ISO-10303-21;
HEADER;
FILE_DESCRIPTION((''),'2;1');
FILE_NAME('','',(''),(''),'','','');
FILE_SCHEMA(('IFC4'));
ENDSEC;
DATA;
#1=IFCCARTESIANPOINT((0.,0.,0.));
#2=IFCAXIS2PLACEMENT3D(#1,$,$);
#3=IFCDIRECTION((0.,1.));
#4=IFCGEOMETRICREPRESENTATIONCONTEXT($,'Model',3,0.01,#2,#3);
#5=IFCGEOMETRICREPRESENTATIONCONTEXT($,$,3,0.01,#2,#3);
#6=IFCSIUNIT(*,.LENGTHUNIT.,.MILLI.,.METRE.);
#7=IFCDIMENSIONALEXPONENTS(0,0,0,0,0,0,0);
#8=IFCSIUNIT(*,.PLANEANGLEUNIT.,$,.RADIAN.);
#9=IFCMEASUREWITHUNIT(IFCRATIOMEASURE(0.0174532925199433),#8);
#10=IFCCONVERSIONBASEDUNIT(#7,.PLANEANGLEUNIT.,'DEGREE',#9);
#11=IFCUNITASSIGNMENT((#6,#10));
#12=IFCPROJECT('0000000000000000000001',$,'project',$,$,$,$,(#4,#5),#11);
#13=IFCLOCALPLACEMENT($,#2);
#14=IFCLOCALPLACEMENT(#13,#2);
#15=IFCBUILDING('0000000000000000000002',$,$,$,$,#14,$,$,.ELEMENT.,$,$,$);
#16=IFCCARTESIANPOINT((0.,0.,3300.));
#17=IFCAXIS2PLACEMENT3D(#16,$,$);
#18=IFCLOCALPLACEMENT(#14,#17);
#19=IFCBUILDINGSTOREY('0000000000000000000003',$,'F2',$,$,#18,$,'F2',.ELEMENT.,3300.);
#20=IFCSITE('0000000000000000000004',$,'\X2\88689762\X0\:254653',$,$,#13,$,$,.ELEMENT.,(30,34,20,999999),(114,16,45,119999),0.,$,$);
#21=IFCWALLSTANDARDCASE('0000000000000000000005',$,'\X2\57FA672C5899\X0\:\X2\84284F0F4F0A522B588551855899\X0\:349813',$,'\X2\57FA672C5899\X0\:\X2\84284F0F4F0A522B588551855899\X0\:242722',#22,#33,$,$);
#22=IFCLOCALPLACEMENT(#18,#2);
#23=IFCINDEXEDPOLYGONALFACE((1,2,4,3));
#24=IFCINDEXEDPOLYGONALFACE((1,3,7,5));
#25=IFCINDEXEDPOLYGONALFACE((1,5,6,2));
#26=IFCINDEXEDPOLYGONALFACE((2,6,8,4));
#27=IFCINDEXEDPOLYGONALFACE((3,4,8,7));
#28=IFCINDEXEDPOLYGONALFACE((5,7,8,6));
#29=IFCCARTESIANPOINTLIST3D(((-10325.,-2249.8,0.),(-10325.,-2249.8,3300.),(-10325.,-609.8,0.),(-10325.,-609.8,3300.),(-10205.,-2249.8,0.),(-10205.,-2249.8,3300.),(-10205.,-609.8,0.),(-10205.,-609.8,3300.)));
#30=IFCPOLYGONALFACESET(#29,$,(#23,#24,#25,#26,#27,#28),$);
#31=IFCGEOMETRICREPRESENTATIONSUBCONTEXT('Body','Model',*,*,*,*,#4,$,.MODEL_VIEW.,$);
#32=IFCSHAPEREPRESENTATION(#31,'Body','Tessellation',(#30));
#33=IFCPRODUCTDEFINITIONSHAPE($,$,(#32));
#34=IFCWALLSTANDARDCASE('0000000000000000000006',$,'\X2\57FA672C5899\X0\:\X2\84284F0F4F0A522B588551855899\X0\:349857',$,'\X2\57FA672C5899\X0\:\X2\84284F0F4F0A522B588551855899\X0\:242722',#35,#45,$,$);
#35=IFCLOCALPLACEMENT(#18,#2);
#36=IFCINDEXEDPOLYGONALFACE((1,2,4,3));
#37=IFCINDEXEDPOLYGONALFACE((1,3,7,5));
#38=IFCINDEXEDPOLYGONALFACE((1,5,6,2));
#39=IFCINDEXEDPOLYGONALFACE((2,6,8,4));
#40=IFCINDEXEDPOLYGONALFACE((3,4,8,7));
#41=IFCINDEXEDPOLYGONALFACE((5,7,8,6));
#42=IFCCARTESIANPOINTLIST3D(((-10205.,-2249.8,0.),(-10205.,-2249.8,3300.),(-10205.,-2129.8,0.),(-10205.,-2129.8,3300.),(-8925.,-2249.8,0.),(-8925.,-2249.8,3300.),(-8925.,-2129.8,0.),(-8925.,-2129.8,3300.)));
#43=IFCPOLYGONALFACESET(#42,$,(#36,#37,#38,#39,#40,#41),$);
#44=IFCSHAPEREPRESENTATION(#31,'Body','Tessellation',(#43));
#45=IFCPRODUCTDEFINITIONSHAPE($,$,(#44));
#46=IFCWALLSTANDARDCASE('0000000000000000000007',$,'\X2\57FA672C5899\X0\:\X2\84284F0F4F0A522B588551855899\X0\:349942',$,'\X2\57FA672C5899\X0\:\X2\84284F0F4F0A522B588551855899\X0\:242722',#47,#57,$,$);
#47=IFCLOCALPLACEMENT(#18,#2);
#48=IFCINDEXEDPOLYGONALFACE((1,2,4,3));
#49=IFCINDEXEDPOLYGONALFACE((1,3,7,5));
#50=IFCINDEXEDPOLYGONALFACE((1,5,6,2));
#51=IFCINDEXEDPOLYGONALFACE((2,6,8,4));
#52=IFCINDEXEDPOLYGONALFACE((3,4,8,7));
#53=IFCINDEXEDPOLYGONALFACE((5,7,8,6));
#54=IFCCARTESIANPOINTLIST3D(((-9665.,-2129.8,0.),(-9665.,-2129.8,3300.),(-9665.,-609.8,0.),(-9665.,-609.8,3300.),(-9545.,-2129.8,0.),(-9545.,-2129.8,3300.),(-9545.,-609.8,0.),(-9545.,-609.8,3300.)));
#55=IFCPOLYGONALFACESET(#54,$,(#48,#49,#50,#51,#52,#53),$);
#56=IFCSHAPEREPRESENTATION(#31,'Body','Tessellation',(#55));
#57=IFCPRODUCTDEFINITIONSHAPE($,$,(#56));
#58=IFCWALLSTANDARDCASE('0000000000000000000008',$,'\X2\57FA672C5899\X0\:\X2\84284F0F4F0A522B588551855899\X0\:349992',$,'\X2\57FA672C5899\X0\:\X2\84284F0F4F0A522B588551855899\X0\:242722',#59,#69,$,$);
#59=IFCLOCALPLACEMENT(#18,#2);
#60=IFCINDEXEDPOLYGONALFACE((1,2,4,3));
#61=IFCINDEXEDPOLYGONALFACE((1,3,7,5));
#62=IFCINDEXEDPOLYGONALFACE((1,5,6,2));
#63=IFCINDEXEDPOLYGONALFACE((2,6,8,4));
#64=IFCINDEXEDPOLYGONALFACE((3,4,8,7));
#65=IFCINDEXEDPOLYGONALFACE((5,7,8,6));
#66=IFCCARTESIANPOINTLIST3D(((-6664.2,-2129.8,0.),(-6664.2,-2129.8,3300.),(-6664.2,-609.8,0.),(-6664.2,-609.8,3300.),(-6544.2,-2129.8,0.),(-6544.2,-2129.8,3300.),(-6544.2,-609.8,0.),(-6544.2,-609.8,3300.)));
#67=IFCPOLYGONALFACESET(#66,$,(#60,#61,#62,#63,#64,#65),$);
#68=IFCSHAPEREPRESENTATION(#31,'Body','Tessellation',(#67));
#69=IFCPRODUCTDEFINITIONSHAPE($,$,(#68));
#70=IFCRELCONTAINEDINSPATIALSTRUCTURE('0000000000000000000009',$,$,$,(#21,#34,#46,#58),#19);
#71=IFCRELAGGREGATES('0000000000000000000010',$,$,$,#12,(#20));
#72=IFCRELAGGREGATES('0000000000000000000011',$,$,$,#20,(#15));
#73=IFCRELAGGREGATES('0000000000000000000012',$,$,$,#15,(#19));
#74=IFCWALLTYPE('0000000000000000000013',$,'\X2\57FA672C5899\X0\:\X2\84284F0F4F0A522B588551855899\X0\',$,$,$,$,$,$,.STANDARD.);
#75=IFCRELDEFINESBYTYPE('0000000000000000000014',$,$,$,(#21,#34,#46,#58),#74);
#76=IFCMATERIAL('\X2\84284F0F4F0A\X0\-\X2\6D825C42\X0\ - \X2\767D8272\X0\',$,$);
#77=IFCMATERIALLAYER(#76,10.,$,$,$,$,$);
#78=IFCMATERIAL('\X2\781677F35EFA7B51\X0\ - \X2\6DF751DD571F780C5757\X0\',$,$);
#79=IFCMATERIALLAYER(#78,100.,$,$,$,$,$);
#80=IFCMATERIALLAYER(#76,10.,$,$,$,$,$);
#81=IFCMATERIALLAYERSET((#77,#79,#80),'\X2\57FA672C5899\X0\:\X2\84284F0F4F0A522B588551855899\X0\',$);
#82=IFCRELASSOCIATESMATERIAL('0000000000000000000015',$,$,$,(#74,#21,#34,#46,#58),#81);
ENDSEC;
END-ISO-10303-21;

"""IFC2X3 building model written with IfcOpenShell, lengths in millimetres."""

from ifc_helpers import new_model, entity, si_unit, converted_unit, direction, frame, frame_2d, origin, place, context, subcontext, project, spatial, rectangle, extrude, material, layer, layer_set, layer_usage, type_object, element, save


model = new_model("IFC2X3")

# Units and contexts
model_context = context("Model", 3, precision=0.01, world=origin(), true_north=direction((0.0, 1.0)))
context_of_model = context(None, 3, precision=0.01, world=origin(), true_north=direction((0.0, 1.0)))
body_context = subcontext(model_context, "Body", "Model", "MODEL_VIEW")
ifc_project = project(units=[si_unit("LENGTHUNIT", "METRE", prefix="MILLI"), converted_unit("PLANEANGLEUNIT", "DEGREE", entity("IfcRatioMeasure", 0.0174532925199433), si_unit("PLANEANGLEUNIT", "RADIAN"), dimensions=[0, 0, 0, 0, 0, 0, 0])], contexts=[model_context, context_of_model])

# Site, building, storey
site_placement = place(None, origin())
site = spatial("IfcSite", under=ifc_project, at=site_placement, Name="表面:254653", CompositionType="ELEMENT", RefLatitude=(30, 34, 20, 999999), RefLongitude=(114, 16, 45, 119999), RefElevation=0.0)
building_placement = place(site_placement, origin())
building = spatial("IfcBuilding", under=site, at=building_placement, CompositionType="ELEMENT")
storey_placement = place(building_placement, frame((0.0, 0.0, 3300.0)))
storey = spatial("IfcBuildingStorey", under=building, at=storey_placement, Name="F2", LongName="F2", CompositionType="ELEMENT", Elevation=3300.0)

# Shared definitions
ifc_material_1 = material(Name="萨伏伊-涂层 - 白色")
ifc_layer_1 = layer(ifc_material_1, 10.0)
ifc_material_2 = material(Name="砖石建筑 - 混凝土砌块")
ifc_layer_2 = layer(ifc_material_2, 100.0)
ifc_layer_3 = layer(ifc_material_1, 10.0)
ifc_layer_set = layer_set([ifc_layer_1, ifc_layer_2, ifc_layer_3], Name="基本墙:萨伏伊别墅内墙")
wall_type = type_object("IfcWallType", Name="基本墙:萨伏伊别墅内墙", PredefinedType="STANDARD", material=ifc_layer_set)

# Walls
ifc_layer_usage_1 = layer_usage(ifc_layer_set, "AXIS2", "NEGATIVE", 60.0)
wall_1_placement = place(storey_placement, frame((-10265.0, -609.8, 0.0), z_axis=(0.0, 0.0, 1.0), x_axis=(0.0, -1.0, 0.0)))
element("IfcWallStandardCase", 1, at=wall_1_placement, inside=storey, type_object=wall_type, material=ifc_layer_usage_1, Name="基本墙:萨伏伊别墅内墙:349813", ObjectType="基本墙:萨伏伊别墅内墙:242722", context=body_context, shape_type="SweptSolid", body=[
    extrude(rectangle(XDim=1640.0, YDim=120.0, at=frame_2d((820.0, 0.0), x_axis=(-1.0, 0.0))), origin(), (0.0, 0.0, 1.0), 3300.0),
])
ifc_layer_usage_2 = layer_usage(ifc_layer_set, "AXIS2", "NEGATIVE", 60.0)
wall_2_placement = place(storey_placement, frame((-10205.0, -2189.8, 0.0)))
element("IfcWallStandardCase", 2, at=wall_2_placement, inside=storey, type_object=wall_type, material=ifc_layer_usage_2, Name="基本墙:萨伏伊别墅内墙:349857", ObjectType="基本墙:萨伏伊别墅内墙:242722", context=body_context, shape_type="SweptSolid", body=[
    extrude(rectangle(XDim=1280.0, YDim=120.0, at=frame_2d((640.0, 0.0), x_axis=(-1.0, 0.0))), origin(), (0.0, 0.0, 1.0), 3300.0),
])
ifc_layer_usage_3 = layer_usage(ifc_layer_set, "AXIS2", "NEGATIVE", 60.0)
wall_3_placement = place(storey_placement, frame((-9605.0, -2129.8, 0.0), z_axis=(0.0, 0.0, 1.0), x_axis=(0.0, 1.0, 0.0)))
element("IfcWallStandardCase", 3, at=wall_3_placement, inside=storey, type_object=wall_type, material=ifc_layer_usage_3, Name="基本墙:萨伏伊别墅内墙:349942", ObjectType="基本墙:萨伏伊别墅内墙:242722", context=body_context, shape_type="SweptSolid", body=[
    extrude(rectangle(XDim=1520.0, YDim=120.0, at=frame_2d((760.0, 0.0), x_axis=(-1.0, 0.0))), origin(), (0.0, 0.0, 1.0), 3300.0),
])
ifc_layer_usage_4 = layer_usage(ifc_layer_set, "AXIS2", "NEGATIVE", 60.0)
wall_4_placement = place(storey_placement, frame((-6604.2, -609.8, 0.0), z_axis=(0.0, 0.0, 1.0), x_axis=(0.0, -1.0, 0.0)))
element("IfcWallStandardCase", 4, at=wall_4_placement, inside=storey, type_object=wall_type, material=ifc_layer_usage_4, Name="基本墙:萨伏伊别墅内墙:349992", ObjectType="基本墙:萨伏伊别墅内墙:242722", context=body_context, shape_type="SweptSolid", body=[
    extrude(rectangle(XDim=1520.0, YDim=120.0, at=frame_2d((760.0, 0.0), x_axis=(-1.0, 0.0))), origin(), (0.0, 0.0, 1.0), 3300.0),
])

save(model, "model.ifc")
